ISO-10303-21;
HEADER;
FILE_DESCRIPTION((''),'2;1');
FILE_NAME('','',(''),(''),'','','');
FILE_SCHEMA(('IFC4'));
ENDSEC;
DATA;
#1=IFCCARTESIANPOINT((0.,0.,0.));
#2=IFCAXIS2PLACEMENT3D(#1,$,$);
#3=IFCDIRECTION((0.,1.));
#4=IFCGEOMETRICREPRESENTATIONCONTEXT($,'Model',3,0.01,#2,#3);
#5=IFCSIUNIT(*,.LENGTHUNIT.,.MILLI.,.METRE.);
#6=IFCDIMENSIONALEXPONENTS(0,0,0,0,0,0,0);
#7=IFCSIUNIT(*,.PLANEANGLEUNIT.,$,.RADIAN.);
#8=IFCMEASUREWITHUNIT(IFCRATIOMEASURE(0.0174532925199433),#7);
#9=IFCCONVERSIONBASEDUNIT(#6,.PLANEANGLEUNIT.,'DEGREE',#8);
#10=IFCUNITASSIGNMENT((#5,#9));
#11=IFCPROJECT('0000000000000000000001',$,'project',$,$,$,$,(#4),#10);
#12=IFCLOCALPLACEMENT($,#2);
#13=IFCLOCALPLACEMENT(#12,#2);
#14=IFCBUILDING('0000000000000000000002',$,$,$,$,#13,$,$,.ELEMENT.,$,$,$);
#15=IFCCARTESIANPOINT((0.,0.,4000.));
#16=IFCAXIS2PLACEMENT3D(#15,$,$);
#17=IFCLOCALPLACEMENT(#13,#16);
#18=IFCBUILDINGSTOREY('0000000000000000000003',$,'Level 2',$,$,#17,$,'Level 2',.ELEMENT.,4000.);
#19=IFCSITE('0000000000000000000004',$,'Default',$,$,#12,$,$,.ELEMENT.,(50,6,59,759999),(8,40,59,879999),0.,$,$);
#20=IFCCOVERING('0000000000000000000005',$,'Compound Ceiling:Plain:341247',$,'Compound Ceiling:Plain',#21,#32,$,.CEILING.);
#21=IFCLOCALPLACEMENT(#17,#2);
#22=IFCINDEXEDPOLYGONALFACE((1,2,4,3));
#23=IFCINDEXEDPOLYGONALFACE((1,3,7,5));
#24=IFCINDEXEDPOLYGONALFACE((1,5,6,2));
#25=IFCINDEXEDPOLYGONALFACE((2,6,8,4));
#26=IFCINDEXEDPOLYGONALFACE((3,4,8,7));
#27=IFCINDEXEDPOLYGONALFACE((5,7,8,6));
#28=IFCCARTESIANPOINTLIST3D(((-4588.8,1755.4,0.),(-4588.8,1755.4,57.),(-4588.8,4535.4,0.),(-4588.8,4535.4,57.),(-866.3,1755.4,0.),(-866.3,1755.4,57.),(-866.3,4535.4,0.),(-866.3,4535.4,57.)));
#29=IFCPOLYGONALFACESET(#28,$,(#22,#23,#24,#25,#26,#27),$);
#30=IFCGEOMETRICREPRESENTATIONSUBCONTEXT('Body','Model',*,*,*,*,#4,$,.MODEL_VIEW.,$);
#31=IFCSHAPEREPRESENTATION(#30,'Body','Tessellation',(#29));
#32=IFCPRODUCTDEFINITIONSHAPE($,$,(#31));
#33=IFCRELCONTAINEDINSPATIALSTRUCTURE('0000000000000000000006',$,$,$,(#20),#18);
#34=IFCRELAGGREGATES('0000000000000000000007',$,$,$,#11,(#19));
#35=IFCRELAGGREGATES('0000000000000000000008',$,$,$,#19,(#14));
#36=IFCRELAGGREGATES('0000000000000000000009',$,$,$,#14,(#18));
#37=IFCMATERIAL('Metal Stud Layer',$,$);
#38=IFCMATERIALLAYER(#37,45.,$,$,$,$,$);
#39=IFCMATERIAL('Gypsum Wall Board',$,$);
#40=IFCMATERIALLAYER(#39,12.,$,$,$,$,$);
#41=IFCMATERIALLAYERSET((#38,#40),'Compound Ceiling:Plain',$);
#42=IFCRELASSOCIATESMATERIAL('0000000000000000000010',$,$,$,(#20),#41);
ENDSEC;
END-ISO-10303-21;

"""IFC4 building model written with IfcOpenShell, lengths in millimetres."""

from ifc_helpers import new_model, entity, si_unit, converted_unit, direction, frame, frame_2d, origin, place, context, subcontext, project, spatial, rectangle, extrude, material, layer, layer_set, layer_usage, element, save


model = new_model("IFC4")

# Units and contexts
model_context = context("Model", 3, precision=0.01, world=origin(), true_north=direction((0.0, 1.0)))
body_context = subcontext(model_context, "Body", "Model", "MODEL_VIEW")
ifc_project = project(units=[si_unit("LENGTHUNIT", "METRE", prefix="MILLI"), converted_unit("PLANEANGLEUNIT", "DEGREE", entity("IfcRatioMeasure", 0.0174532925199433), si_unit("PLANEANGLEUNIT", "RADIAN"), dimensions=[0, 0, 0, 0, 0, 0, 0])], contexts=[model_context])

# Site, building, storey
site_placement = place(None, origin())
site = spatial("IfcSite", under=ifc_project, at=site_placement, Name="Default", CompositionType="ELEMENT", RefLatitude=(50, 6, 59, 759999), RefLongitude=(8, 40, 59, 879999), RefElevation=0.0)
building_placement = place(site_placement, origin())
building = spatial("IfcBuilding", under=site, at=building_placement, CompositionType="ELEMENT")
storey_placement = place(building_placement, frame((0.0, 0.0, 4000.0)))
storey = spatial("IfcBuildingStorey", under=building, at=storey_placement, Name="Level 2", LongName="Level 2", CompositionType="ELEMENT", Elevation=4000.0)

# Covering
ifc_material_1 = material(Name="Metal Stud Layer")
ifc_layer_1 = layer(ifc_material_1, 45.0)
ifc_material_2 = material(Name="Gypsum Wall Board")
ifc_layer_2 = layer(ifc_material_2, 12.0)
ifc_layer_set = layer_set([ifc_layer_1, ifc_layer_2], Name="Compound Ceiling:Plain")
ifc_layer_usage = layer_usage(ifc_layer_set, "AXIS3", "POSITIVE", 0.0)
covering_placement = place(storey_placement, frame((-4588.8, 1755.4, 0.0)))
element("IfcCovering", 1, at=covering_placement, inside=storey, material=ifc_layer_usage, Name="Compound Ceiling:Plain:341247", ObjectType="Compound Ceiling:Plain", PredefinedType="CEILING", context=body_context, shape_type="SweptSolid", body=[
    extrude(rectangle(XDim=2780.0, YDim=3722.5, at=frame_2d((0.0, 0.0), x_axis=(1.0, 0.0))), frame((1861.2, 1390.0, 0.0), z_axis=(0.0, 0.0, 1.0), x_axis=(0.0, -1.0, 0.0)), (0.0, 0.0, 1.0), 57.0),
])

save(model, "model.ifc")
